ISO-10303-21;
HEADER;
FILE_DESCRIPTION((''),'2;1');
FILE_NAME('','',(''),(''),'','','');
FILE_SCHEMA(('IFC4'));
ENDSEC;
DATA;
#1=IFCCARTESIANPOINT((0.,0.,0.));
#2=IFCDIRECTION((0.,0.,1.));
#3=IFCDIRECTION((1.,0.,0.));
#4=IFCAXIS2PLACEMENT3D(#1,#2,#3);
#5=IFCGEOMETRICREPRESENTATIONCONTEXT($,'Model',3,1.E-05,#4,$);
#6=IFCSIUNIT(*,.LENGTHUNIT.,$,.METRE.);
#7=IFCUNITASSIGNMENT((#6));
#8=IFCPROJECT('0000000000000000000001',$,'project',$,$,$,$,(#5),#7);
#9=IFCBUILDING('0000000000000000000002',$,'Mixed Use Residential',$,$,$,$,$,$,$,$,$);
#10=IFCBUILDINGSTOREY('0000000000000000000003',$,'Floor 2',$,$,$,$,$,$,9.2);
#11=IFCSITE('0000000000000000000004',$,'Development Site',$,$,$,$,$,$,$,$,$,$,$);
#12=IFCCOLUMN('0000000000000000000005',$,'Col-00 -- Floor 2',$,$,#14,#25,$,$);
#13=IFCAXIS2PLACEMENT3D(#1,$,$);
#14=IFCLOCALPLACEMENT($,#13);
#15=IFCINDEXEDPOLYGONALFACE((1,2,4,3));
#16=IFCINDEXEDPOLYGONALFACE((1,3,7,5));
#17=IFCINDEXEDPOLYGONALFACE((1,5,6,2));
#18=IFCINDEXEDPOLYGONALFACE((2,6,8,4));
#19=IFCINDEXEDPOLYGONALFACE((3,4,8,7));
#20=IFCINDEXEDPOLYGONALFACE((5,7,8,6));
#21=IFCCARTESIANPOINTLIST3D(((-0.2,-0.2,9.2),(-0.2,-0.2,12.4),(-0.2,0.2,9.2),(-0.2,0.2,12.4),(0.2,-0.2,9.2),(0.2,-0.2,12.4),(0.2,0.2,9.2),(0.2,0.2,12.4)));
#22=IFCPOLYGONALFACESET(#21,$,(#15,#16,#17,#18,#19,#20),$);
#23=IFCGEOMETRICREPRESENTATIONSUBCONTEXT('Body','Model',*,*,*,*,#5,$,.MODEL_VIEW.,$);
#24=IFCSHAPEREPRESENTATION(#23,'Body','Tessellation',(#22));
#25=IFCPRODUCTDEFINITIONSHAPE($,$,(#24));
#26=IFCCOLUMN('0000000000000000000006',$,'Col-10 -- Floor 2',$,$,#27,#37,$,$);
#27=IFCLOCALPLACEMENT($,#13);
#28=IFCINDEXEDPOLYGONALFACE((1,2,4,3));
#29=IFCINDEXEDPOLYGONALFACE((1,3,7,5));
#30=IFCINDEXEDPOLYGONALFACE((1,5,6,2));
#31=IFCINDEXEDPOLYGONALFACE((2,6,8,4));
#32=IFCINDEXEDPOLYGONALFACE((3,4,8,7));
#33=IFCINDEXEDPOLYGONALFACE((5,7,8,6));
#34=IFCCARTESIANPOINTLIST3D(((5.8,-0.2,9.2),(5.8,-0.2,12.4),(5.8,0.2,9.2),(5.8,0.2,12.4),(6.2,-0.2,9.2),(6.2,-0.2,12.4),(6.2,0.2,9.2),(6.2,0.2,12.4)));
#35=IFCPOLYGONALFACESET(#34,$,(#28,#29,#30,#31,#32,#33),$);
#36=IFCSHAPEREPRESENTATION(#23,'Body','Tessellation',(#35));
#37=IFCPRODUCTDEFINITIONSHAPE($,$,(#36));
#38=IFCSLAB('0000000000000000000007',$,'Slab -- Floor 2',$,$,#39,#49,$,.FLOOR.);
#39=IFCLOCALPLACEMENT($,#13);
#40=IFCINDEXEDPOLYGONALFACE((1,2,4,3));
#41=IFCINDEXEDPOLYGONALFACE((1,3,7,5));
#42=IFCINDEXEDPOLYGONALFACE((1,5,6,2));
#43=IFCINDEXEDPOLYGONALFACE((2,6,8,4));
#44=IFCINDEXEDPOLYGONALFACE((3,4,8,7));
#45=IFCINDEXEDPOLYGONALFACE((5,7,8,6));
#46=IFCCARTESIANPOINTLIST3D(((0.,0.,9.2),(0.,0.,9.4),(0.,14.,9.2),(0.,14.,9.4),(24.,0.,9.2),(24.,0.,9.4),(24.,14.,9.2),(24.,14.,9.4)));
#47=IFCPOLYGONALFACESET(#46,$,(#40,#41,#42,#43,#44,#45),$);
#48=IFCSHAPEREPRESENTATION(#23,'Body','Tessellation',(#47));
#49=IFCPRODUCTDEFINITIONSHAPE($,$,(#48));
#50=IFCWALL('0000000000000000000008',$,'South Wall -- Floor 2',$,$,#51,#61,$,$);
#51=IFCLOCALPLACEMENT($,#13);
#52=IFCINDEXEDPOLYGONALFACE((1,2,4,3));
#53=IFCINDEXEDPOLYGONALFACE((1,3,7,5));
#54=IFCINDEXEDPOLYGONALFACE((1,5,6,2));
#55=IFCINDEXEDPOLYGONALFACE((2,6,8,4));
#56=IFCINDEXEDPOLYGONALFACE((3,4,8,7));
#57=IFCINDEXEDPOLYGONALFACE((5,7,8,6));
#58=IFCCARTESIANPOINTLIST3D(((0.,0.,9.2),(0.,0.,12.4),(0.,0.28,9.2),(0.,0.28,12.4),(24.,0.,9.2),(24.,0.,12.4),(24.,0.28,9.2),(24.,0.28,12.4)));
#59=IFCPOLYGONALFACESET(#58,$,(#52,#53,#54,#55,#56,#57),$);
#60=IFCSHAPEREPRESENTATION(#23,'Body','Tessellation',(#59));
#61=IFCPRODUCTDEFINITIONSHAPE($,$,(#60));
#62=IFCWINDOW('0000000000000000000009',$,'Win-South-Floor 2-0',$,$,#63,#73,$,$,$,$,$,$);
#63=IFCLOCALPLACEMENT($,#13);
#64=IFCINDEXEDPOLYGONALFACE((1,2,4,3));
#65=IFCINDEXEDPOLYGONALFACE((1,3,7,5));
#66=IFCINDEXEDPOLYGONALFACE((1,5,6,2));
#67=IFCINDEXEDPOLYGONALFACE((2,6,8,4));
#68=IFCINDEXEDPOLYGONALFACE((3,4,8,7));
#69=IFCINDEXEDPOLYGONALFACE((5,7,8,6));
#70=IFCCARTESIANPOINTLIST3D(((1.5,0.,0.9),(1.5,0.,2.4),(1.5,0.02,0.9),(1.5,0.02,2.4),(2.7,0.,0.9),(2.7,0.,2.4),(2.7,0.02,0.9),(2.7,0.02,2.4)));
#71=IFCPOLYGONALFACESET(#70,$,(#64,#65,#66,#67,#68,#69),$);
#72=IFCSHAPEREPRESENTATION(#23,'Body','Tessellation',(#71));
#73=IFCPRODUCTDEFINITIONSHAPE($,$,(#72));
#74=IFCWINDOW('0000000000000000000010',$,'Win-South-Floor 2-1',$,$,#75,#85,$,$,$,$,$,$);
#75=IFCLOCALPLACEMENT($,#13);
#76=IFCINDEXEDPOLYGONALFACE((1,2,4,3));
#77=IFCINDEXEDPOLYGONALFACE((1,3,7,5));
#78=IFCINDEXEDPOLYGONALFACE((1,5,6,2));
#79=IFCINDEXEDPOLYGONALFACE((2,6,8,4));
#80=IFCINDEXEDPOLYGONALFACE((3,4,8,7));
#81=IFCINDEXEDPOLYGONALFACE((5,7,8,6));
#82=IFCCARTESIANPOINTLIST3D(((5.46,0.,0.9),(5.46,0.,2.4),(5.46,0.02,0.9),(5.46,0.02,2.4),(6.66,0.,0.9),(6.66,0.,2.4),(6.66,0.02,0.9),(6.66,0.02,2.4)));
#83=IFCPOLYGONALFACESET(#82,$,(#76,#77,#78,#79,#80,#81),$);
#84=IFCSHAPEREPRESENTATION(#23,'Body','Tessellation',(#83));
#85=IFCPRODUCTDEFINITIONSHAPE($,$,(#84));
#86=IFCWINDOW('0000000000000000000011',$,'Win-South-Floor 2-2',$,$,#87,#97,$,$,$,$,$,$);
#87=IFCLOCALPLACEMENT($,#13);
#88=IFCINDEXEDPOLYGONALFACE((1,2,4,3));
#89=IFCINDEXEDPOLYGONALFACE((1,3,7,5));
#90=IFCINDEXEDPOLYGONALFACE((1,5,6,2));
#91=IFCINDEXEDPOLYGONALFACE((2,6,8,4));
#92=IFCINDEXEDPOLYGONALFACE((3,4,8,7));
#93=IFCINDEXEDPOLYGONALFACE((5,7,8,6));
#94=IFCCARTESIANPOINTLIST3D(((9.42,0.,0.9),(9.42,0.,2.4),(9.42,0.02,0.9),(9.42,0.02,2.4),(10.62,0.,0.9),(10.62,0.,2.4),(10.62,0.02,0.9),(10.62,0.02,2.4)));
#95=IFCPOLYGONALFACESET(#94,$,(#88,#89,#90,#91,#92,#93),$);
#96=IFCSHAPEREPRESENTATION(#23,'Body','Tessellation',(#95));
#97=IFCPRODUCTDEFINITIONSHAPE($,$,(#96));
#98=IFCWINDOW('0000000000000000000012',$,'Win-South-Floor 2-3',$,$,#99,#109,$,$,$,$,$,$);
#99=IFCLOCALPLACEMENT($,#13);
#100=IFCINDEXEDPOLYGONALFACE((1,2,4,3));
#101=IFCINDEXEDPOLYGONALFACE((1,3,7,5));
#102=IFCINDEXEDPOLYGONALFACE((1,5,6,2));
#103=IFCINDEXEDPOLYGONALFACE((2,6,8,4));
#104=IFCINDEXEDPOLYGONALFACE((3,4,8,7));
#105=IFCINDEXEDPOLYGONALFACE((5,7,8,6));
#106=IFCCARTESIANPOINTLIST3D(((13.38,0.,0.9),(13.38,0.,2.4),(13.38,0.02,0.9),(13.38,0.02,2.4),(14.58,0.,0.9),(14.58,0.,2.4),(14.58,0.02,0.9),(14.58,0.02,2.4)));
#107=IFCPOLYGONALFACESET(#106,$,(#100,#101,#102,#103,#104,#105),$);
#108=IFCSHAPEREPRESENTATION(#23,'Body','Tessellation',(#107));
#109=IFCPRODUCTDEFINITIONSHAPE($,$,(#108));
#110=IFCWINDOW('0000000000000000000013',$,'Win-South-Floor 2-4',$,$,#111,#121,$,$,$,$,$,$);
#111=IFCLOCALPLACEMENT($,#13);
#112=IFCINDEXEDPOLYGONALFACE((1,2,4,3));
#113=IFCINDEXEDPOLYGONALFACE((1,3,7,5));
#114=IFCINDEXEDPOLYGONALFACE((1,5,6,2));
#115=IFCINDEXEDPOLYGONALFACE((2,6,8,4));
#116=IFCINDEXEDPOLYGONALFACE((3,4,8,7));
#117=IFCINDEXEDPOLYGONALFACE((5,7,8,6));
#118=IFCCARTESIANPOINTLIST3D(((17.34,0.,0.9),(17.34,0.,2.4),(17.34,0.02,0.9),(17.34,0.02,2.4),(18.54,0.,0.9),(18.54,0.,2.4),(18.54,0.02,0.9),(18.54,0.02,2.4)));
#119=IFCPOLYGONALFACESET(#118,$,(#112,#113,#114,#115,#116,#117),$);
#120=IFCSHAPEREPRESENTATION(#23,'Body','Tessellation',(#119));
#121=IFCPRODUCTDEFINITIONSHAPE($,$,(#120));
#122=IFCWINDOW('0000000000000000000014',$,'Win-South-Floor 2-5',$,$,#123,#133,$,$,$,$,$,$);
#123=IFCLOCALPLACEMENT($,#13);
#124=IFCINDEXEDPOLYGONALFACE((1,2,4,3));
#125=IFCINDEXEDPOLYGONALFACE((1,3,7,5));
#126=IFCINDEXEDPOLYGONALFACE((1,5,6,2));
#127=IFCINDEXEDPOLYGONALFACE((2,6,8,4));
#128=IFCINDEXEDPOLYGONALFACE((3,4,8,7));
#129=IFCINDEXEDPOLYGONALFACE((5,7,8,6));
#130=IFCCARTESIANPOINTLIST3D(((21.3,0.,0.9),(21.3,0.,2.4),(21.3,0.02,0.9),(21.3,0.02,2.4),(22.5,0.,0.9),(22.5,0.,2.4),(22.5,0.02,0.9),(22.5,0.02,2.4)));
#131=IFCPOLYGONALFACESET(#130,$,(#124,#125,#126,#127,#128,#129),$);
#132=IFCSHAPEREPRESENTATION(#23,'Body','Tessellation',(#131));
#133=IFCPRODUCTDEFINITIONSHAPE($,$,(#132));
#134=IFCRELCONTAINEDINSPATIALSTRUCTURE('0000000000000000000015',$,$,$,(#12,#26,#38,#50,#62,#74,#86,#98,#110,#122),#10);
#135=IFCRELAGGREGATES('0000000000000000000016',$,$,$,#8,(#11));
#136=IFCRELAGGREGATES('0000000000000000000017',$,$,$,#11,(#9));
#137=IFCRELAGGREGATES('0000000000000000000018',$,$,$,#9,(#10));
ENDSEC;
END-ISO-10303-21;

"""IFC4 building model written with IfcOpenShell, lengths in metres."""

from ifc_helpers import new_model, si_unit, frame, origin_with_axes, place, context, subcontext, project, spatial, indexed_curve, rectangle, outline, extrude, element, fill, save


model = new_model("IFC4")

# Units and contexts
model_context = context("Model", 3, precision=1e-05, world=origin_with_axes())
body_context = subcontext(model_context, "Body", "Model", "MODEL_VIEW")
ifc_project = project(units=[si_unit("LENGTHUNIT", "METRE")], contexts=[model_context])

# Site, building, storey
site = spatial("IfcSite", under=ifc_project, Name="Development Site")
building = spatial("IfcBuilding", under=site, Name="Mixed Use Residential")
storey = spatial("IfcBuildingStorey", under=building, Name="Floor 2", Elevation=9.2)

# Columns
for number, where, z_axis, x_axis, name in (
    (1, (0.0, 0.0, 9.2), (0.0, 0.0, 1.0), (1.0, 0.0, 0.0), "Col-00 -- Floor 2"),
    (2, (6.0, 0.0, 9.2), (0.0, 0.0, 1.0), (1.0, 0.0, 0.0), "Col-10 -- Floor 2"),
):
    element("IfcColumn", number, at=place(None, frame(where, z_axis=z_axis, x_axis=x_axis)), inside=storey, Name=name, context=body_context, shape_type="SweptSolid", body=[
        extrude(rectangle(XDim=0.4, YDim=0.4), origin_with_axes(), (0.0, 0.0, 1.0), 3.2),
    ])

# Slab
slab_placement = place(None, frame((0.0, 0.0, 9.2), z_axis=(0.0, 0.0, 1.0), x_axis=(1.0, 0.0, 0.0)))
element("IfcSlab", 3, at=slab_placement, inside=storey, Name="Slab -- Floor 2", PredefinedType="FLOOR", context=body_context, shape_type="SweptSolid", body=[
    extrude(outline(indexed_curve([(0.0, 0.0), (24.0, 0.0), (24.0, 14.0), (0.0, 14.0), (0.0, 0.0)])), None, (0.0, 0.0, 1.0), 0.2),
])

# Wall, openings, windows
wall_1_placement = place(None, frame((0.0, 0.0, 9.2), z_axis=(0.0, 0.0, 1.0), x_axis=(1.0, 0.0, 0.0)))
wall_1 = element("IfcWall", 4, at=wall_1_placement, inside=storey, Name="South Wall -- Floor 2", context=body_context, shape_type="SweptSolid", body=[
    extrude(outline(indexed_curve([(0.0, 0.0), (0.0, 0.28), (24.0, 0.28), (24.0, 0.0), (0.0, 0.0)], self_intersect=False)), origin_with_axes(), (0.0, 0.0, 1.0), 3.2),
])
opening_1_placement = place(wall_1_placement, frame((1.5, 0.0, -8.3), z_axis=(0.0, 0.0, 1.0), x_axis=(1.0, 0.0, 0.0)))
opening_1 = element("IfcOpeningElement", 5, at=opening_1_placement, cuts=wall_1, context=body_context, shape_type="SweptSolid", body=[
    extrude(outline(indexed_curve([(0.0, 0.0), (0.0, 0.28), (1.2, 0.28), (1.2, 0.0), (0.0, 0.0)], self_intersect=False)), origin_with_axes(), (0.0, 0.0, 1.0), 1.5),
])
opening_2_placement = place(wall_1_placement, frame((5.46, 0.0, -8.3), z_axis=(0.0, 0.0, 1.0), x_axis=(1.0, 0.0, 0.0)))
opening_2 = element("IfcOpeningElement", 6, at=opening_2_placement, cuts=wall_1, context=body_context, shape_type="SweptSolid", body=[
    extrude(outline(indexed_curve([(0.0, 0.0), (0.0, 0.28), (1.2, 0.28), (1.2, 0.0), (0.0, 0.0)], self_intersect=False)), origin_with_axes(), (0.0, 0.0, 1.0), 1.5),
])
opening_3_placement = place(wall_1_placement, frame((9.42, 0.0, -8.3), z_axis=(0.0, 0.0, 1.0), x_axis=(1.0, 0.0, 0.0)))
opening_3 = element("IfcOpeningElement", 7, at=opening_3_placement, cuts=wall_1, context=body_context, shape_type="SweptSolid", body=[
    extrude(outline(indexed_curve([(0.0, 0.0), (0.0, 0.28), (1.2, 0.28), (1.2, 0.0), (0.0, 0.0)], self_intersect=False)), origin_with_axes(), (0.0, 0.0, 1.0), 1.5),
])
opening_4_placement = place(wall_1_placement, frame((13.38, 0.0, -8.3), z_axis=(0.0, 0.0, 1.0), x_axis=(1.0, 0.0, 0.0)))
opening_4 = element("IfcOpeningElement", 8, at=opening_4_placement, cuts=wall_1, context=body_context, shape_type="SweptSolid", body=[
    extrude(outline(indexed_curve([(0.0, 0.0), (0.0, 0.28), (1.2, 0.28), (1.2, 0.0), (0.0, 0.0)], self_intersect=False)), origin_with_axes(), (0.0, 0.0, 1.0), 1.5),
])
opening_5_placement = place(wall_1_placement, frame((17.34, 0.0, -8.3), z_axis=(0.0, 0.0, 1.0), x_axis=(1.0, 0.0, 0.0)))
opening_5 = element("IfcOpeningElement", 9, at=opening_5_placement, cuts=wall_1, context=body_context, shape_type="SweptSolid", body=[
    extrude(outline(indexed_curve([(0.0, 0.0), (0.0, 0.28), (1.2, 0.28), (1.2, 0.0), (0.0, 0.0)], self_intersect=False)), origin_with_axes(), (0.0, 0.0, 1.0), 1.5),
])
opening_6_placement = place(wall_1_placement, frame((21.3, 0.0, -8.3), z_axis=(0.0, 0.0, 1.0), x_axis=(1.0, 0.0, 0.0)))
opening_6 = element("IfcOpeningElement", 10, at=opening_6_placement, cuts=wall_1, context=body_context, shape_type="SweptSolid", body=[
    extrude(outline(indexed_curve([(0.0, 0.0), (0.0, 0.28), (1.2, 0.28), (1.2, 0.0), (0.0, 0.0)], self_intersect=False)), origin_with_axes(), (0.0, 0.0, 1.0), 1.5),
])
window_1_placement = place(None, frame((1.5, 0.0, 0.9), z_axis=(0.0, 0.0, 1.0), x_axis=(1.0, 0.0, 0.0)))
window_1 = element("IfcWindow", 11, at=window_1_placement, inside=storey, Name="Win-South-Floor 2-0", context=body_context, shape_type="SweptSolid", body=[
    extrude(outline(indexed_curve([(0.0, 0.0), (0.0, 0.02), (1.2, 0.02), (1.2, 0.0), (0.0, 0.0)], self_intersect=False)), origin_with_axes(), (0.0, 0.0, 1.0), 1.5),
])
fill(opening_1, window_1)
window_2_placement = place(None, frame((5.46, 0.0, 0.9), z_axis=(0.0, 0.0, 1.0), x_axis=(1.0, 0.0, 0.0)))
window_2 = element("IfcWindow", 12, at=window_2_placement, inside=storey, Name="Win-South-Floor 2-1", context=body_context, shape_type="SweptSolid", body=[
    extrude(outline(indexed_curve([(0.0, 0.0), (0.0, 0.02), (1.2, 0.02), (1.2, 0.0), (0.0, 0.0)], self_intersect=False)), origin_with_axes(), (0.0, 0.0, 1.0), 1.5),
])
fill(opening_2, window_2)
window_3_placement = place(None, frame((9.42, 0.0, 0.9), z_axis=(0.0, 0.0, 1.0), x_axis=(1.0, 0.0, 0.0)))
window_3 = element("IfcWindow", 13, at=window_3_placement, inside=storey, Name="Win-South-Floor 2-2", context=body_context, shape_type="SweptSolid", body=[
    extrude(outline(indexed_curve([(0.0, 0.0), (0.0, 0.02), (1.2, 0.02), (1.2, 0.0), (0.0, 0.0)], self_intersect=False)), origin_with_axes(), (0.0, 0.0, 1.0), 1.5),
])
fill(opening_3, window_3)
window_4_placement = place(None, frame((13.38, 0.0, 0.9), z_axis=(0.0, 0.0, 1.0), x_axis=(1.0, 0.0, 0.0)))
window_4 = element("IfcWindow", 14, at=window_4_placement, inside=storey, Name="Win-South-Floor 2-3", context=body_context, shape_type="SweptSolid", body=[
    extrude(outline(indexed_curve([(0.0, 0.0), (0.0, 0.02), (1.2, 0.02), (1.2, 0.0), (0.0, 0.0)], self_intersect=False)), origin_with_axes(), (0.0, 0.0, 1.0), 1.5),
])
fill(opening_4, window_4)
window_5_placement = place(None, frame((17.34, 0.0, 0.9), z_axis=(0.0, 0.0, 1.0), x_axis=(1.0, 0.0, 0.0)))
window_5 = element("IfcWindow", 15, at=window_5_placement, inside=storey, Name="Win-South-Floor 2-4", context=body_context, shape_type="SweptSolid", body=[
    extrude(outline(indexed_curve([(0.0, 0.0), (0.0, 0.02), (1.2, 0.02), (1.2, 0.0), (0.0, 0.0)], self_intersect=False)), origin_with_axes(), (0.0, 0.0, 1.0), 1.5),
])
fill(opening_5, window_5)
window_6_placement = place(None, frame((21.3, 0.0, 0.9), z_axis=(0.0, 0.0, 1.0), x_axis=(1.0, 0.0, 0.0)))
window_6 = element("IfcWindow", 16, at=window_6_placement, inside=storey, Name="Win-South-Floor 2-5", context=body_context, shape_type="SweptSolid", body=[
    extrude(outline(indexed_curve([(0.0, 0.0), (0.0, 0.02), (1.2, 0.02), (1.2, 0.0), (0.0, 0.0)], self_intersect=False)), origin_with_axes(), (0.0, 0.0, 1.0), 1.5),
])
fill(opening_6, window_6)

save(model, "model.ifc")
